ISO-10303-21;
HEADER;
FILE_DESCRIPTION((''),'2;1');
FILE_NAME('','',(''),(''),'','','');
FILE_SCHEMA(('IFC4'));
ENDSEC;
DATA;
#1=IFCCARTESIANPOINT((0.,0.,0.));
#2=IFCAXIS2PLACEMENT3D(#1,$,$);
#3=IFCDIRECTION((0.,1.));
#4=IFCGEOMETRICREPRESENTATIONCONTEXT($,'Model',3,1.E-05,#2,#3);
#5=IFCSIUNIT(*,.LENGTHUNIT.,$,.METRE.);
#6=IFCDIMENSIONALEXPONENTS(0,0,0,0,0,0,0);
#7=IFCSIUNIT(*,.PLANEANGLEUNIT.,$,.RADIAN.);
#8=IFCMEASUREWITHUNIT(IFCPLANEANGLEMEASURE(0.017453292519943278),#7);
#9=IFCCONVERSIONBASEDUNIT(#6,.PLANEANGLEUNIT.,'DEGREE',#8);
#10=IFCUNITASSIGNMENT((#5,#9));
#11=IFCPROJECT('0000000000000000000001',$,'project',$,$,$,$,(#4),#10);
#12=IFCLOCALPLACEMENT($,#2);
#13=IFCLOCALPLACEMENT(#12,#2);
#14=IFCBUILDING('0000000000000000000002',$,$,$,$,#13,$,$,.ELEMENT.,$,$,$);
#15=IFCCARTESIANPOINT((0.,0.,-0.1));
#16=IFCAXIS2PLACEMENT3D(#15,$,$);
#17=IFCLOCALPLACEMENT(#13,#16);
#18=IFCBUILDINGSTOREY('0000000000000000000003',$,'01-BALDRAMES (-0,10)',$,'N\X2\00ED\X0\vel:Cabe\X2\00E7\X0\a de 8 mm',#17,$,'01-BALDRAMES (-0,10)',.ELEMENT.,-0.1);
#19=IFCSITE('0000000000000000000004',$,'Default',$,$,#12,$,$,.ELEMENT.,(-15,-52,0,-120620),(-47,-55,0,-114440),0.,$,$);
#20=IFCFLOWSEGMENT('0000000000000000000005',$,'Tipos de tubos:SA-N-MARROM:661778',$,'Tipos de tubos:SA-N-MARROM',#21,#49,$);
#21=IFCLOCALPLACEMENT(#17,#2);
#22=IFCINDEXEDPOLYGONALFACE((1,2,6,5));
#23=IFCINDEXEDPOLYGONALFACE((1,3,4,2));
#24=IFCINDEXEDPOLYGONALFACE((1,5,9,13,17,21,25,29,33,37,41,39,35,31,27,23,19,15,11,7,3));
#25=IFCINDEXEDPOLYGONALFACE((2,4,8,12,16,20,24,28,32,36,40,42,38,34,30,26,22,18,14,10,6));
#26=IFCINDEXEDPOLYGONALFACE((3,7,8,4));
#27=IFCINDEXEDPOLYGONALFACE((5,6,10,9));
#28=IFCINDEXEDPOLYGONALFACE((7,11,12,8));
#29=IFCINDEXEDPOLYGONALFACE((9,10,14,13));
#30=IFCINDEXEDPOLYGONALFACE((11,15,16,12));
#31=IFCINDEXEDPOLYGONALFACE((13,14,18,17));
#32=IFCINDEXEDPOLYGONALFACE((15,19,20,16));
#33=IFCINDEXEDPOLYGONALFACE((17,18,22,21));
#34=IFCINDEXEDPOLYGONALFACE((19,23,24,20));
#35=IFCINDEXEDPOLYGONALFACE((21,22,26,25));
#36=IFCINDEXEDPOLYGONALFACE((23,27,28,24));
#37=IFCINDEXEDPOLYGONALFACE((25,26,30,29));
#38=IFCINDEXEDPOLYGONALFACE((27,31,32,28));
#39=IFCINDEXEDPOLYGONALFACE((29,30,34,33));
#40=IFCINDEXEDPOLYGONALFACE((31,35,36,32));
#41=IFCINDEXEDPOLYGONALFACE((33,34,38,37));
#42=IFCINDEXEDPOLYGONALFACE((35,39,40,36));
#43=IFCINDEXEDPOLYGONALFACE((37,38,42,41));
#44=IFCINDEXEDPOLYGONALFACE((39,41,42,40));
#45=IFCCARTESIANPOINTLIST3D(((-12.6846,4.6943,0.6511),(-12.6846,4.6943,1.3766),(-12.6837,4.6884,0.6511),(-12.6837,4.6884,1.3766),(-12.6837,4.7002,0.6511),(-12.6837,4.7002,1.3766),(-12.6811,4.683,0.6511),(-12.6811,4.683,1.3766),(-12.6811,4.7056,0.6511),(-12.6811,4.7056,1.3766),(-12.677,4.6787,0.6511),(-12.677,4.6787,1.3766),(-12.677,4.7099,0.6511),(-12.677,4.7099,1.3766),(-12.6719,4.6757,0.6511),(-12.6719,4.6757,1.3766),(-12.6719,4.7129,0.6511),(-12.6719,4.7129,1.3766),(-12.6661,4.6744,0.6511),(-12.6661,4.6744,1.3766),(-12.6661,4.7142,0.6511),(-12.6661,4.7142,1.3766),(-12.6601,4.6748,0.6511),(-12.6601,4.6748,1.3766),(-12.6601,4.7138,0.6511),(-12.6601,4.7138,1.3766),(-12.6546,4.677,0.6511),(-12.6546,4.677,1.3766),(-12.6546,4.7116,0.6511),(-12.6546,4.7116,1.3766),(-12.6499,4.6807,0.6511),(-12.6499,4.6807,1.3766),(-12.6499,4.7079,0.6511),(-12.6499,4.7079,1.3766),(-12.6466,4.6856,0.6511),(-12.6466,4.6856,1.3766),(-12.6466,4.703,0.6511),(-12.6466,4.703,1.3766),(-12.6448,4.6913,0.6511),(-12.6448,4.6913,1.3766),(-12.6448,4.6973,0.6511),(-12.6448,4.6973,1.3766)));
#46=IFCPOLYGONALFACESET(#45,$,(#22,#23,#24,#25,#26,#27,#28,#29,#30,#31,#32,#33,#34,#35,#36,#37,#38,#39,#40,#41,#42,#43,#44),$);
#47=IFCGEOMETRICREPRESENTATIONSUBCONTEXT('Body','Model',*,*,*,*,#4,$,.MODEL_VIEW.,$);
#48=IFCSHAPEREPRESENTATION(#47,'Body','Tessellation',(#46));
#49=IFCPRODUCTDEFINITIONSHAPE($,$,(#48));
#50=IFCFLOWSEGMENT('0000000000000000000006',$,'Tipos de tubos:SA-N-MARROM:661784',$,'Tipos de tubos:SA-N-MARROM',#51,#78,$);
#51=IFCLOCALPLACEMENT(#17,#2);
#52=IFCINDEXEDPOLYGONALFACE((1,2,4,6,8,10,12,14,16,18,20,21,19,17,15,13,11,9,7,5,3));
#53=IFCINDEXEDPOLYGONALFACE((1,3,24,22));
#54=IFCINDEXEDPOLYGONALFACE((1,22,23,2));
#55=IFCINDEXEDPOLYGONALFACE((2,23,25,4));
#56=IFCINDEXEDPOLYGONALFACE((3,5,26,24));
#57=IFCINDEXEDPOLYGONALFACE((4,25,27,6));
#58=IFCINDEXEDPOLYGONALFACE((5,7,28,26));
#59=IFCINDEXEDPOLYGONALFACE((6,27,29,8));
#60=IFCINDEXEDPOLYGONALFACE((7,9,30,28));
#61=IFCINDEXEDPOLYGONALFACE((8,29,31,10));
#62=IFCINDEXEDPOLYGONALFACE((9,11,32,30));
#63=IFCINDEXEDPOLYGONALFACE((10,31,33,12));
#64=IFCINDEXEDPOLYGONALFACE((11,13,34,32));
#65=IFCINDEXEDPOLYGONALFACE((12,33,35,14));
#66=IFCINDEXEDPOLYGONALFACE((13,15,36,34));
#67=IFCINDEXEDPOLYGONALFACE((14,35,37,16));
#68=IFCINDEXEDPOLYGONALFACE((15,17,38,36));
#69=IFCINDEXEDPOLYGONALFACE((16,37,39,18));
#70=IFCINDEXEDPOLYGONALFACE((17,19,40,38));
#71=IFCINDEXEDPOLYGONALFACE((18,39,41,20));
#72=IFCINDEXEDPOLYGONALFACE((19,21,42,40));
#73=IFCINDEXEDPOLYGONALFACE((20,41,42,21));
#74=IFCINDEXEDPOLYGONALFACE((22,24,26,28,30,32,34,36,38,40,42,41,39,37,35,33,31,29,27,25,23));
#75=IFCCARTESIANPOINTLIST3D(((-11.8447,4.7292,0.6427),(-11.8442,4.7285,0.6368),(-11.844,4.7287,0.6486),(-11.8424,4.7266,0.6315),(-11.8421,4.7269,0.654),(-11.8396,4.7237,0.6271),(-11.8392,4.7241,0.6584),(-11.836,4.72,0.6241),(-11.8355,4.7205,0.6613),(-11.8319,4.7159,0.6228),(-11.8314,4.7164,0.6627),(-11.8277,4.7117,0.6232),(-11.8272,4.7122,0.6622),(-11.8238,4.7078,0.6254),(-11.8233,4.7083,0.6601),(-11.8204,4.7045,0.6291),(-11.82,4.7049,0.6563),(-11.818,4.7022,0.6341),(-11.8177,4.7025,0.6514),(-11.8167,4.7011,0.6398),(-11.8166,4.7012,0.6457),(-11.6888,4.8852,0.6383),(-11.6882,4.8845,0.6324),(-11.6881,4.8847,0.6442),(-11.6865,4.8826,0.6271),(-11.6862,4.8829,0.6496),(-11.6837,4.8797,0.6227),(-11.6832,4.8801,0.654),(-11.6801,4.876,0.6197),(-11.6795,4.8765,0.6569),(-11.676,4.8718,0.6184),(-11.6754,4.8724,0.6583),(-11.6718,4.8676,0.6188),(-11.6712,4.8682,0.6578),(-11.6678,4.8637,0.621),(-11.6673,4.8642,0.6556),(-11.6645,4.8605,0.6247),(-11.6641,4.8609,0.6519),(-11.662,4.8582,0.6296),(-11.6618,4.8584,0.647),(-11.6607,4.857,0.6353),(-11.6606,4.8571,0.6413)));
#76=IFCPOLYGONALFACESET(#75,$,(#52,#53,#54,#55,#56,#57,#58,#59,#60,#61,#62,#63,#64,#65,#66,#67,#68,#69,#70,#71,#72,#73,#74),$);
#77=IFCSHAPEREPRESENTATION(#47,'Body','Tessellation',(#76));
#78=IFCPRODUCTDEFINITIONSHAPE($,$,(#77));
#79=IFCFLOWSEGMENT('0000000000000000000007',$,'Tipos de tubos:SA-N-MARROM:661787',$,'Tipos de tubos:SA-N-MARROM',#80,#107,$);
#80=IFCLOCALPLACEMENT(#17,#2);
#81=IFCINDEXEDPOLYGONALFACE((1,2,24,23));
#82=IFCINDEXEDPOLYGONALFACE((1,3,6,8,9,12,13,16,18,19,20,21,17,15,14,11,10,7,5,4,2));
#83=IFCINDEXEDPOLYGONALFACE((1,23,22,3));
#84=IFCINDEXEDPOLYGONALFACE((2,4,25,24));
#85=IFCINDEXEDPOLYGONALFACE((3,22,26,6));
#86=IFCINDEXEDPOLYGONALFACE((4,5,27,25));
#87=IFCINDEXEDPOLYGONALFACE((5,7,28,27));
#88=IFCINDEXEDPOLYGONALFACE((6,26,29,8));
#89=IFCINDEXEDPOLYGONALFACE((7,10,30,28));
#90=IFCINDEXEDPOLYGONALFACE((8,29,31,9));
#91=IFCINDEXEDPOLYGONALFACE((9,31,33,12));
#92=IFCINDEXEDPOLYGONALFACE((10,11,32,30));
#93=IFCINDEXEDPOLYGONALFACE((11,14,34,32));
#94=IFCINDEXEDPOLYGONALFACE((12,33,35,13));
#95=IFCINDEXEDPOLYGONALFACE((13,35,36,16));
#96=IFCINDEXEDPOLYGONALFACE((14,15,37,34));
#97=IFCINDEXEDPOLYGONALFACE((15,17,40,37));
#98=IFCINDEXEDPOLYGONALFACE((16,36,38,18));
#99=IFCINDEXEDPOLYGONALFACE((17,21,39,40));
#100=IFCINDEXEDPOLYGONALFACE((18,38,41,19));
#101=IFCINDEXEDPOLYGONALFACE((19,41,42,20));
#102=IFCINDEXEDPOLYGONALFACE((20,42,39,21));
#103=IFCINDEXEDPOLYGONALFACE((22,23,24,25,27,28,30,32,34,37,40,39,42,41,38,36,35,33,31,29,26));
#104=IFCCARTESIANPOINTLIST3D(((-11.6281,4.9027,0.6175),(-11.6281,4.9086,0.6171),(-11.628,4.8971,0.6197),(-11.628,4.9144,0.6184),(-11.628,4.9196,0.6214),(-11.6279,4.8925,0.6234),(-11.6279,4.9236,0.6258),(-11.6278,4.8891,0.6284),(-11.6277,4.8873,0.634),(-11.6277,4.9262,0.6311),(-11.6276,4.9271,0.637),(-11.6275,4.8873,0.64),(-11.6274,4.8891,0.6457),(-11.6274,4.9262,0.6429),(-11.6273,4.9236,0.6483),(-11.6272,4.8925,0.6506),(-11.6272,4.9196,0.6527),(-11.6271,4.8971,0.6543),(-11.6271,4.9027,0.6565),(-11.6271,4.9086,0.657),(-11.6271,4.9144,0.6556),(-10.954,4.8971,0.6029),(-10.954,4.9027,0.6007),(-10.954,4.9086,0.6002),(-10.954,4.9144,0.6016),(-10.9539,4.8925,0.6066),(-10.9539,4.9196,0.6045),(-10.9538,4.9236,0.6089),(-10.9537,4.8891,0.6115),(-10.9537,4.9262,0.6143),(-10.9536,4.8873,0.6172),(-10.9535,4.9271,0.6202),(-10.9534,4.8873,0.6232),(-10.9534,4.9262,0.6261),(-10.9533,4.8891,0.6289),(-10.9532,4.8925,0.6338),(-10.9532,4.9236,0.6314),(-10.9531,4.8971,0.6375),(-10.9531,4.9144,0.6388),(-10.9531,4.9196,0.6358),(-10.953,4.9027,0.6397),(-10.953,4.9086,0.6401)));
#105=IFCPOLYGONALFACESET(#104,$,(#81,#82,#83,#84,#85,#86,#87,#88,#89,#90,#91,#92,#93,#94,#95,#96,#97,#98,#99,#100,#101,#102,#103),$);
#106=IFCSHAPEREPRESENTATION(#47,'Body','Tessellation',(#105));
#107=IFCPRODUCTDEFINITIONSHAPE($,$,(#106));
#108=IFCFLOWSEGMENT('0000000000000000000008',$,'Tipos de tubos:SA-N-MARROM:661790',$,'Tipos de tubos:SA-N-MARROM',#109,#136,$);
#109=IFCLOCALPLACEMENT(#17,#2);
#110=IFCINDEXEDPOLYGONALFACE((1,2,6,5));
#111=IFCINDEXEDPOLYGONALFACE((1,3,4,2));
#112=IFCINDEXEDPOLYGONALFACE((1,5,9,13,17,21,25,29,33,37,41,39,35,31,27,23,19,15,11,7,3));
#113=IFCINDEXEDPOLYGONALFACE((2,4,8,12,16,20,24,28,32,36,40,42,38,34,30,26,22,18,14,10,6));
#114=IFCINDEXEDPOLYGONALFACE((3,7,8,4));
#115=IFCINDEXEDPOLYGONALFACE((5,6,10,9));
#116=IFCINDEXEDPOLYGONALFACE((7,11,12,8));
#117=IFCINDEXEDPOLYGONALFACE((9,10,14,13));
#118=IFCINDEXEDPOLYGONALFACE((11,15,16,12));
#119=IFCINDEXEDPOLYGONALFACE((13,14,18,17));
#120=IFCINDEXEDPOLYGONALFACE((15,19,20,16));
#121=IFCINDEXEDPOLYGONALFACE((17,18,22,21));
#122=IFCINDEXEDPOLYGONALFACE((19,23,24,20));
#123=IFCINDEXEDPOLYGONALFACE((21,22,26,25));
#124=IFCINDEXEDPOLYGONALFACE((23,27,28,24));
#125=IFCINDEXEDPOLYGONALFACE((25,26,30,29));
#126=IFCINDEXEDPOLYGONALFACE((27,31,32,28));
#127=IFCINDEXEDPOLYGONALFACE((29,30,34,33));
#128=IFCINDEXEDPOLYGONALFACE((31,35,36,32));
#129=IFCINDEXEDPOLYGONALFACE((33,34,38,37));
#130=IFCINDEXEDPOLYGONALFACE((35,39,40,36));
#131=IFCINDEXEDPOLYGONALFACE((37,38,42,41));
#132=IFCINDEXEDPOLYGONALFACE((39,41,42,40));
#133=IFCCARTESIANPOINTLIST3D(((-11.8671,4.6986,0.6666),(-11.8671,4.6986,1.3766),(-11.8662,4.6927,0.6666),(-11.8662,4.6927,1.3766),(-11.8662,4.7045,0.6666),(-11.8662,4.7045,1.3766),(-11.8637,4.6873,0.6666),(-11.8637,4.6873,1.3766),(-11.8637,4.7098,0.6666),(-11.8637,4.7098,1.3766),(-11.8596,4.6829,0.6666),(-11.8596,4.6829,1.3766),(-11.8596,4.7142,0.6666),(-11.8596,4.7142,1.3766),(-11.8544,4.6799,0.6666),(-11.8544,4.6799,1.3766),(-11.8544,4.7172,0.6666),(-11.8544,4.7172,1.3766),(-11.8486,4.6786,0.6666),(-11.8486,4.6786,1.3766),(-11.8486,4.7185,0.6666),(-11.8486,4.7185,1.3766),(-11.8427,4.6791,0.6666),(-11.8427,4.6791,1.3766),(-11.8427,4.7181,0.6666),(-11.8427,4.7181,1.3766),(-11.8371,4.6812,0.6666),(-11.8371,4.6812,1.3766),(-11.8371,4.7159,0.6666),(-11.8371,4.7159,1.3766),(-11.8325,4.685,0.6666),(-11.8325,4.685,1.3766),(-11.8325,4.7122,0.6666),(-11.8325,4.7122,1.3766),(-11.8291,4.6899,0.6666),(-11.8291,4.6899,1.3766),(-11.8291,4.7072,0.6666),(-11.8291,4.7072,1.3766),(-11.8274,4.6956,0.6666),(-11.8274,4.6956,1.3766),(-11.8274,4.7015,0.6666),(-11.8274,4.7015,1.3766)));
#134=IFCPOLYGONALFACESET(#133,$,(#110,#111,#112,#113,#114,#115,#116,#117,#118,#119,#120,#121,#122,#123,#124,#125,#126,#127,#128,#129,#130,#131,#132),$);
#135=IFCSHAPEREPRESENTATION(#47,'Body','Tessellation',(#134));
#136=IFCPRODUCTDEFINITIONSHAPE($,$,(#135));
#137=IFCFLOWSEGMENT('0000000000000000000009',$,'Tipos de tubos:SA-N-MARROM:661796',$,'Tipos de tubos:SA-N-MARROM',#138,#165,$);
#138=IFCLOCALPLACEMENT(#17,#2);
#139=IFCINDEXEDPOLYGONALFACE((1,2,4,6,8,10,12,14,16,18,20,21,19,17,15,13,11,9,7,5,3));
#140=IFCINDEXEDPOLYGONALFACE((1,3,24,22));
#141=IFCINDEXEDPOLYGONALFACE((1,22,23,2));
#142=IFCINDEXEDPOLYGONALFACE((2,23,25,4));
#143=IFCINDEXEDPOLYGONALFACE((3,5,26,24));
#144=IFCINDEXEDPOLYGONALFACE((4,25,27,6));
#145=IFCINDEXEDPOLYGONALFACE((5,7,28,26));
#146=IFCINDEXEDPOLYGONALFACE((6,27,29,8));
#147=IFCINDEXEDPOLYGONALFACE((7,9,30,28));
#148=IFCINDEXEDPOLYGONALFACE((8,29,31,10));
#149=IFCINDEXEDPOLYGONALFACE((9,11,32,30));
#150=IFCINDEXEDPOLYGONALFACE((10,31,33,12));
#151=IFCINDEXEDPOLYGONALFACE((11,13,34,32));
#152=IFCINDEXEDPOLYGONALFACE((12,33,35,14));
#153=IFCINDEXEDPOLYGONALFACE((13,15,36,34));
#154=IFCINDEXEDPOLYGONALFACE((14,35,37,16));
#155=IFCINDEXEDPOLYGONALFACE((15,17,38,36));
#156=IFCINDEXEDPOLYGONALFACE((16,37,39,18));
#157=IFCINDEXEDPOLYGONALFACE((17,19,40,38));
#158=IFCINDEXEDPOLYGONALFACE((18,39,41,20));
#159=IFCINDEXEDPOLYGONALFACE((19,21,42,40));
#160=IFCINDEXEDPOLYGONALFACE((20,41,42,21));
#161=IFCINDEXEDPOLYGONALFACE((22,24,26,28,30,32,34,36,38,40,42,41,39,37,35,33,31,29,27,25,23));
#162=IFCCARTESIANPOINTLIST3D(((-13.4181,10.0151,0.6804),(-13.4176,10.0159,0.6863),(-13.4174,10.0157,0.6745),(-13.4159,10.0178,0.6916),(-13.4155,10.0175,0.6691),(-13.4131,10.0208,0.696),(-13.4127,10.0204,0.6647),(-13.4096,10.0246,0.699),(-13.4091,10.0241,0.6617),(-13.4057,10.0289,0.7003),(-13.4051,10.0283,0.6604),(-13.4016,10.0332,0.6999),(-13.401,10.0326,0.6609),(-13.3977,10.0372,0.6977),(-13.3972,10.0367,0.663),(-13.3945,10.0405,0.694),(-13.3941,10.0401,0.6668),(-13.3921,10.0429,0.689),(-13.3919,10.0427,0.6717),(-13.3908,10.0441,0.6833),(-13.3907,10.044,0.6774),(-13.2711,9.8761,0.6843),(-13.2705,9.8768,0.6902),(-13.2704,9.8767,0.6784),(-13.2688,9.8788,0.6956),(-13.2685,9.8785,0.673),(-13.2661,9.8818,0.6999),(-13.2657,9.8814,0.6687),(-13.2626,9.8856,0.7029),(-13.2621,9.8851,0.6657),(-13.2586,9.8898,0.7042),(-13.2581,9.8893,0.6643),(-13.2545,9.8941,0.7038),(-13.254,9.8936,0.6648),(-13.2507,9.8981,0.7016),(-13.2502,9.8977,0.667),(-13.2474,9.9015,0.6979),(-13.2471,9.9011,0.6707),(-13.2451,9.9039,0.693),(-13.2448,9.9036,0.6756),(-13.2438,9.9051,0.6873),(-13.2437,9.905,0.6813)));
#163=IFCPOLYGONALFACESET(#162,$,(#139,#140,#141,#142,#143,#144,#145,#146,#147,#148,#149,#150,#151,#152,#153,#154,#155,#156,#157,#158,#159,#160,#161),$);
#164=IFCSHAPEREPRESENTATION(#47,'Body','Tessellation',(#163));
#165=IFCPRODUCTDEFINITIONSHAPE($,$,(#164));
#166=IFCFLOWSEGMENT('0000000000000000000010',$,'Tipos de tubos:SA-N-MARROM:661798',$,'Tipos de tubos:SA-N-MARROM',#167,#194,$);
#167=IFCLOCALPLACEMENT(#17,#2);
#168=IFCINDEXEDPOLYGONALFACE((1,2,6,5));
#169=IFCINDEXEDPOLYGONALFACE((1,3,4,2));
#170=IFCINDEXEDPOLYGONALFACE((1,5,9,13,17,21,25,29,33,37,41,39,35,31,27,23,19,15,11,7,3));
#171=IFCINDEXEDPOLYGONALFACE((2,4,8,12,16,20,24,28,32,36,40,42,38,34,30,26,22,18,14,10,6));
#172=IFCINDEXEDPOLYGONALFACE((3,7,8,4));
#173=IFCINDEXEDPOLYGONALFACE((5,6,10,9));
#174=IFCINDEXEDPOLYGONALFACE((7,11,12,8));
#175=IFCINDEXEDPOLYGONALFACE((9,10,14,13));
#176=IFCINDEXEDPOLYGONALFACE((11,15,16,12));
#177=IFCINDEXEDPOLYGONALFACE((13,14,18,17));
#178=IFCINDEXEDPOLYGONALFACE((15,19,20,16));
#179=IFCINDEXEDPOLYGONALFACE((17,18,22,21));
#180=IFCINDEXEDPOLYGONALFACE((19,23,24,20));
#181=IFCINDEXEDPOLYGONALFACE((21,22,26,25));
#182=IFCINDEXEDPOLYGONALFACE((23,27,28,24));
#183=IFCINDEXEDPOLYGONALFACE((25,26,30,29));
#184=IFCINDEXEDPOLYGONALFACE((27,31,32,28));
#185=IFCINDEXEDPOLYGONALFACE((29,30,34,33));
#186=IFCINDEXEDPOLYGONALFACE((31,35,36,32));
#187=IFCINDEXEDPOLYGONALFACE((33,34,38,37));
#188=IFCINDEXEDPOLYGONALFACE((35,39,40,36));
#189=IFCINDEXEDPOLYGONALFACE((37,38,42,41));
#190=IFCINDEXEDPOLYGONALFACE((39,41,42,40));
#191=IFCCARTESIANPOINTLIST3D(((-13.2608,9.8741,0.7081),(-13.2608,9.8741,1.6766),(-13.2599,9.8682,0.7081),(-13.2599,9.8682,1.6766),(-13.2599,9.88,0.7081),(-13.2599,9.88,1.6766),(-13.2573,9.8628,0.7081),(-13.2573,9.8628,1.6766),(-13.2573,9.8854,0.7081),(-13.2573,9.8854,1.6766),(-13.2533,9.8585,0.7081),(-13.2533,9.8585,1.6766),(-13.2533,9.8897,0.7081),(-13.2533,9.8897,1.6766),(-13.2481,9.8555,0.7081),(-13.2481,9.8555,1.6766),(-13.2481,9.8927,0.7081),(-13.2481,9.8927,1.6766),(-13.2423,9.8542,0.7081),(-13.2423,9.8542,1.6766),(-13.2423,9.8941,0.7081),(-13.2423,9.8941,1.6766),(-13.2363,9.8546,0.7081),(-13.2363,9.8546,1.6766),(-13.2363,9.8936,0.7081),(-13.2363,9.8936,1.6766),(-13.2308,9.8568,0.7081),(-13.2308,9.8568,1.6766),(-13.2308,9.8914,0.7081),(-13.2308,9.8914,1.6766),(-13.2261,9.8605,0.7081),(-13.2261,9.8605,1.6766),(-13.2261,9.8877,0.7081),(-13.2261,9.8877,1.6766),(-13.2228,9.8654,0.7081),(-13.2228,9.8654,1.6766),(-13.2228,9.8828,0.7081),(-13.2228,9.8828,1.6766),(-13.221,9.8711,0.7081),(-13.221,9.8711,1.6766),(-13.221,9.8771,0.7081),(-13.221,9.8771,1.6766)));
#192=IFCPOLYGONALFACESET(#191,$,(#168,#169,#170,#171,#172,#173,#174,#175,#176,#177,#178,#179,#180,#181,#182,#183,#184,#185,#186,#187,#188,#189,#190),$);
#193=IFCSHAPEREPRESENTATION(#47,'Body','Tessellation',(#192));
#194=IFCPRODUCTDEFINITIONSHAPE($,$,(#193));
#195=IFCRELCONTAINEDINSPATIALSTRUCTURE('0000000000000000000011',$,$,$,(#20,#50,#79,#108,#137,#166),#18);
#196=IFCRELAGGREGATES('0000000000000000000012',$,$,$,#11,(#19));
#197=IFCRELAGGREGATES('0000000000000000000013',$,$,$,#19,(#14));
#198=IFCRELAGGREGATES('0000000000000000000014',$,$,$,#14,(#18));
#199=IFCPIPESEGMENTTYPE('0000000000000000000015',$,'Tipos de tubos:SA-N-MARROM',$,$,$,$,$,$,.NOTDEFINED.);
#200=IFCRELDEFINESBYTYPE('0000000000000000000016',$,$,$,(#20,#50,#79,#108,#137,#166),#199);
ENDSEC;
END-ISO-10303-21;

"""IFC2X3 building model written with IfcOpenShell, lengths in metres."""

from ifc_helpers import new_model, entity, si_unit, converted_unit, direction, frame, frame_2d, origin, origin_2d_with_axis, place, context, subcontext, project, spatial, circle, extrude, type_object, element, save


model = new_model("IFC2X3")

# Units and contexts
model_context = context("Model", 3, precision=1e-05, world=origin(), true_north=direction((0.0, 1.0)))
body_context = subcontext(model_context, "Body", "Model", "MODEL_VIEW")
ifc_project = project(units=[si_unit("LENGTHUNIT", "METRE"), converted_unit("PLANEANGLEUNIT", "DEGREE", entity("IfcPlaneAngleMeasure", 0.017453292519943278), si_unit("PLANEANGLEUNIT", "RADIAN"), dimensions=[0, 0, 0, 0, 0, 0, 0])], contexts=[model_context])

# Site, building, storey
site_placement = place(None, origin())
site = spatial("IfcSite", under=ifc_project, at=site_placement, Name="Default", CompositionType="ELEMENT", RefLatitude=(-15, -52, 0, -120620), RefLongitude=(-47, -55, 0, -114440), RefElevation=0.0)
building_placement = place(site_placement, origin())
building = spatial("IfcBuilding", under=site, at=building_placement, CompositionType="ELEMENT")
storey_placement = place(building_placement, frame((0.0, 0.0, -0.1)))
storey = spatial("IfcBuildingStorey", under=building, at=storey_placement, Name="01-BALDRAMES (-0,10)", ObjectType="Nível:Cabeça de 8 mm", LongName="01-BALDRAMES (-0,10)", CompositionType="ELEMENT", Elevation=-0.1)

# Flow segments
pipe_segment_type_1 = type_object("IfcPipeSegmentType", Name="Tipos de tubos:SA-N-MARROM", PredefinedType="NOTDEFINED")
flow_segment_1_placement = place(storey_placement, origin())
element("IfcFlowSegment", 1, at=flow_segment_1_placement, inside=storey, type_object=pipe_segment_type_1, Name="Tipos de tubos:SA-N-MARROM:661778", ObjectType="Tipos de tubos:SA-N-MARROM", context=body_context, shape_type="SweptSolid", body=[
    extrude(circle(Radius=0.02, at=origin_2d_with_axis()), frame((-12.6646, 4.6943, 0.6511), z_axis=(0.0, 0.0, 1.0), x_axis=(-1.0, 0.0, 0.0)), (0.0, 0.0, 1.0), 0.7255),
])
flow_segment_2_placement = place(storey_placement, origin())
element("IfcFlowSegment", 2, at=flow_segment_2_placement, inside=storey, type_object=pipe_segment_type_1, Name="Tipos de tubos:SA-N-MARROM:661784", ObjectType="Tipos de tubos:SA-N-MARROM", context=body_context, shape_type="SweptSolid", body=[
    extrude(circle(Radius=0.02, at=origin_2d_with_axis()), frame((-11.8306, 4.7151, 0.6427), z_axis=(0.706965, 0.706966, -0.019996), x_axis=(-0.707107, 0.707106, 0.0)), (0.0, 0.0, 1.0), 0.2206),
])
flow_segment_3_placement = place(storey_placement, origin())
element("IfcFlowSegment", 3, at=flow_segment_3_placement, inside=storey, type_object=pipe_segment_type_1, Name="Tipos de tubos:SA-N-MARROM:661787", ObjectType="Tipos de tubos:SA-N-MARROM", context=body_context, shape_type="SweptSolid", body=[
    extrude(circle(Radius=0.02, at=origin_2d_with_axis()), frame((-11.6276, 4.9071, 0.637), z_axis=(0.999688, 0.000001, -0.024995), x_axis=(-0.000001, 1.0, 0.0)), (0.0, 0.0, 1.0), 0.6743),
])
flow_segment_4_placement = place(storey_placement, origin())
element("IfcFlowSegment", 4, at=flow_segment_4_placement, inside=storey, type_object=pipe_segment_type_1, Name="Tipos de tubos:SA-N-MARROM:661790", ObjectType="Tipos de tubos:SA-N-MARROM", context=body_context, shape_type="SweptSolid", body=[
    extrude(circle(Radius=0.02, at=origin_2d_with_axis()), frame((-11.8471, 4.6986, 0.6666), z_axis=(0.0, 0.0, 1.0), x_axis=(-1.0, 0.0, 0.0)), (0.0, 0.0, 1.0), 0.71),
])
flow_segment_5_placement = place(storey_placement, origin())
element("IfcFlowSegment", 5, at=flow_segment_5_placement, inside=storey, type_object=pipe_segment_type_1, Name="Tipos de tubos:SA-N-MARROM:661796", ObjectType="Tipos de tubos:SA-N-MARROM", context=body_context, shape_type="SweptSolid", body=[
    extrude(circle(Radius=0.02, at=frame_2d((0.0, 0.0), x_axis=(1.0, 0.0))), frame((-13.4044, 10.0297, 0.6804), z_axis=(0.726459, -0.686935, 0.019429), x_axis=(-0.687065, -0.726596, 0.0)), (0.0, 0.0, 1.0), 0.2024),
])
flow_segment_6_placement = place(storey_placement, origin())
element("IfcFlowSegment", 6, at=flow_segment_6_placement, inside=storey, type_object=pipe_segment_type_1, Name="Tipos de tubos:SA-N-MARROM:661798", ObjectType="Tipos de tubos:SA-N-MARROM", context=body_context, shape_type="SweptSolid", body=[
    extrude(circle(Radius=0.02, at=origin_2d_with_axis()), frame((-13.2408, 9.8741, 0.7081), z_axis=(0.0, 0.0, 1.0), x_axis=(-1.0, 0.0, 0.0)), (0.0, 0.0, 1.0), 0.9685),
])

save(model, "model.ifc")
